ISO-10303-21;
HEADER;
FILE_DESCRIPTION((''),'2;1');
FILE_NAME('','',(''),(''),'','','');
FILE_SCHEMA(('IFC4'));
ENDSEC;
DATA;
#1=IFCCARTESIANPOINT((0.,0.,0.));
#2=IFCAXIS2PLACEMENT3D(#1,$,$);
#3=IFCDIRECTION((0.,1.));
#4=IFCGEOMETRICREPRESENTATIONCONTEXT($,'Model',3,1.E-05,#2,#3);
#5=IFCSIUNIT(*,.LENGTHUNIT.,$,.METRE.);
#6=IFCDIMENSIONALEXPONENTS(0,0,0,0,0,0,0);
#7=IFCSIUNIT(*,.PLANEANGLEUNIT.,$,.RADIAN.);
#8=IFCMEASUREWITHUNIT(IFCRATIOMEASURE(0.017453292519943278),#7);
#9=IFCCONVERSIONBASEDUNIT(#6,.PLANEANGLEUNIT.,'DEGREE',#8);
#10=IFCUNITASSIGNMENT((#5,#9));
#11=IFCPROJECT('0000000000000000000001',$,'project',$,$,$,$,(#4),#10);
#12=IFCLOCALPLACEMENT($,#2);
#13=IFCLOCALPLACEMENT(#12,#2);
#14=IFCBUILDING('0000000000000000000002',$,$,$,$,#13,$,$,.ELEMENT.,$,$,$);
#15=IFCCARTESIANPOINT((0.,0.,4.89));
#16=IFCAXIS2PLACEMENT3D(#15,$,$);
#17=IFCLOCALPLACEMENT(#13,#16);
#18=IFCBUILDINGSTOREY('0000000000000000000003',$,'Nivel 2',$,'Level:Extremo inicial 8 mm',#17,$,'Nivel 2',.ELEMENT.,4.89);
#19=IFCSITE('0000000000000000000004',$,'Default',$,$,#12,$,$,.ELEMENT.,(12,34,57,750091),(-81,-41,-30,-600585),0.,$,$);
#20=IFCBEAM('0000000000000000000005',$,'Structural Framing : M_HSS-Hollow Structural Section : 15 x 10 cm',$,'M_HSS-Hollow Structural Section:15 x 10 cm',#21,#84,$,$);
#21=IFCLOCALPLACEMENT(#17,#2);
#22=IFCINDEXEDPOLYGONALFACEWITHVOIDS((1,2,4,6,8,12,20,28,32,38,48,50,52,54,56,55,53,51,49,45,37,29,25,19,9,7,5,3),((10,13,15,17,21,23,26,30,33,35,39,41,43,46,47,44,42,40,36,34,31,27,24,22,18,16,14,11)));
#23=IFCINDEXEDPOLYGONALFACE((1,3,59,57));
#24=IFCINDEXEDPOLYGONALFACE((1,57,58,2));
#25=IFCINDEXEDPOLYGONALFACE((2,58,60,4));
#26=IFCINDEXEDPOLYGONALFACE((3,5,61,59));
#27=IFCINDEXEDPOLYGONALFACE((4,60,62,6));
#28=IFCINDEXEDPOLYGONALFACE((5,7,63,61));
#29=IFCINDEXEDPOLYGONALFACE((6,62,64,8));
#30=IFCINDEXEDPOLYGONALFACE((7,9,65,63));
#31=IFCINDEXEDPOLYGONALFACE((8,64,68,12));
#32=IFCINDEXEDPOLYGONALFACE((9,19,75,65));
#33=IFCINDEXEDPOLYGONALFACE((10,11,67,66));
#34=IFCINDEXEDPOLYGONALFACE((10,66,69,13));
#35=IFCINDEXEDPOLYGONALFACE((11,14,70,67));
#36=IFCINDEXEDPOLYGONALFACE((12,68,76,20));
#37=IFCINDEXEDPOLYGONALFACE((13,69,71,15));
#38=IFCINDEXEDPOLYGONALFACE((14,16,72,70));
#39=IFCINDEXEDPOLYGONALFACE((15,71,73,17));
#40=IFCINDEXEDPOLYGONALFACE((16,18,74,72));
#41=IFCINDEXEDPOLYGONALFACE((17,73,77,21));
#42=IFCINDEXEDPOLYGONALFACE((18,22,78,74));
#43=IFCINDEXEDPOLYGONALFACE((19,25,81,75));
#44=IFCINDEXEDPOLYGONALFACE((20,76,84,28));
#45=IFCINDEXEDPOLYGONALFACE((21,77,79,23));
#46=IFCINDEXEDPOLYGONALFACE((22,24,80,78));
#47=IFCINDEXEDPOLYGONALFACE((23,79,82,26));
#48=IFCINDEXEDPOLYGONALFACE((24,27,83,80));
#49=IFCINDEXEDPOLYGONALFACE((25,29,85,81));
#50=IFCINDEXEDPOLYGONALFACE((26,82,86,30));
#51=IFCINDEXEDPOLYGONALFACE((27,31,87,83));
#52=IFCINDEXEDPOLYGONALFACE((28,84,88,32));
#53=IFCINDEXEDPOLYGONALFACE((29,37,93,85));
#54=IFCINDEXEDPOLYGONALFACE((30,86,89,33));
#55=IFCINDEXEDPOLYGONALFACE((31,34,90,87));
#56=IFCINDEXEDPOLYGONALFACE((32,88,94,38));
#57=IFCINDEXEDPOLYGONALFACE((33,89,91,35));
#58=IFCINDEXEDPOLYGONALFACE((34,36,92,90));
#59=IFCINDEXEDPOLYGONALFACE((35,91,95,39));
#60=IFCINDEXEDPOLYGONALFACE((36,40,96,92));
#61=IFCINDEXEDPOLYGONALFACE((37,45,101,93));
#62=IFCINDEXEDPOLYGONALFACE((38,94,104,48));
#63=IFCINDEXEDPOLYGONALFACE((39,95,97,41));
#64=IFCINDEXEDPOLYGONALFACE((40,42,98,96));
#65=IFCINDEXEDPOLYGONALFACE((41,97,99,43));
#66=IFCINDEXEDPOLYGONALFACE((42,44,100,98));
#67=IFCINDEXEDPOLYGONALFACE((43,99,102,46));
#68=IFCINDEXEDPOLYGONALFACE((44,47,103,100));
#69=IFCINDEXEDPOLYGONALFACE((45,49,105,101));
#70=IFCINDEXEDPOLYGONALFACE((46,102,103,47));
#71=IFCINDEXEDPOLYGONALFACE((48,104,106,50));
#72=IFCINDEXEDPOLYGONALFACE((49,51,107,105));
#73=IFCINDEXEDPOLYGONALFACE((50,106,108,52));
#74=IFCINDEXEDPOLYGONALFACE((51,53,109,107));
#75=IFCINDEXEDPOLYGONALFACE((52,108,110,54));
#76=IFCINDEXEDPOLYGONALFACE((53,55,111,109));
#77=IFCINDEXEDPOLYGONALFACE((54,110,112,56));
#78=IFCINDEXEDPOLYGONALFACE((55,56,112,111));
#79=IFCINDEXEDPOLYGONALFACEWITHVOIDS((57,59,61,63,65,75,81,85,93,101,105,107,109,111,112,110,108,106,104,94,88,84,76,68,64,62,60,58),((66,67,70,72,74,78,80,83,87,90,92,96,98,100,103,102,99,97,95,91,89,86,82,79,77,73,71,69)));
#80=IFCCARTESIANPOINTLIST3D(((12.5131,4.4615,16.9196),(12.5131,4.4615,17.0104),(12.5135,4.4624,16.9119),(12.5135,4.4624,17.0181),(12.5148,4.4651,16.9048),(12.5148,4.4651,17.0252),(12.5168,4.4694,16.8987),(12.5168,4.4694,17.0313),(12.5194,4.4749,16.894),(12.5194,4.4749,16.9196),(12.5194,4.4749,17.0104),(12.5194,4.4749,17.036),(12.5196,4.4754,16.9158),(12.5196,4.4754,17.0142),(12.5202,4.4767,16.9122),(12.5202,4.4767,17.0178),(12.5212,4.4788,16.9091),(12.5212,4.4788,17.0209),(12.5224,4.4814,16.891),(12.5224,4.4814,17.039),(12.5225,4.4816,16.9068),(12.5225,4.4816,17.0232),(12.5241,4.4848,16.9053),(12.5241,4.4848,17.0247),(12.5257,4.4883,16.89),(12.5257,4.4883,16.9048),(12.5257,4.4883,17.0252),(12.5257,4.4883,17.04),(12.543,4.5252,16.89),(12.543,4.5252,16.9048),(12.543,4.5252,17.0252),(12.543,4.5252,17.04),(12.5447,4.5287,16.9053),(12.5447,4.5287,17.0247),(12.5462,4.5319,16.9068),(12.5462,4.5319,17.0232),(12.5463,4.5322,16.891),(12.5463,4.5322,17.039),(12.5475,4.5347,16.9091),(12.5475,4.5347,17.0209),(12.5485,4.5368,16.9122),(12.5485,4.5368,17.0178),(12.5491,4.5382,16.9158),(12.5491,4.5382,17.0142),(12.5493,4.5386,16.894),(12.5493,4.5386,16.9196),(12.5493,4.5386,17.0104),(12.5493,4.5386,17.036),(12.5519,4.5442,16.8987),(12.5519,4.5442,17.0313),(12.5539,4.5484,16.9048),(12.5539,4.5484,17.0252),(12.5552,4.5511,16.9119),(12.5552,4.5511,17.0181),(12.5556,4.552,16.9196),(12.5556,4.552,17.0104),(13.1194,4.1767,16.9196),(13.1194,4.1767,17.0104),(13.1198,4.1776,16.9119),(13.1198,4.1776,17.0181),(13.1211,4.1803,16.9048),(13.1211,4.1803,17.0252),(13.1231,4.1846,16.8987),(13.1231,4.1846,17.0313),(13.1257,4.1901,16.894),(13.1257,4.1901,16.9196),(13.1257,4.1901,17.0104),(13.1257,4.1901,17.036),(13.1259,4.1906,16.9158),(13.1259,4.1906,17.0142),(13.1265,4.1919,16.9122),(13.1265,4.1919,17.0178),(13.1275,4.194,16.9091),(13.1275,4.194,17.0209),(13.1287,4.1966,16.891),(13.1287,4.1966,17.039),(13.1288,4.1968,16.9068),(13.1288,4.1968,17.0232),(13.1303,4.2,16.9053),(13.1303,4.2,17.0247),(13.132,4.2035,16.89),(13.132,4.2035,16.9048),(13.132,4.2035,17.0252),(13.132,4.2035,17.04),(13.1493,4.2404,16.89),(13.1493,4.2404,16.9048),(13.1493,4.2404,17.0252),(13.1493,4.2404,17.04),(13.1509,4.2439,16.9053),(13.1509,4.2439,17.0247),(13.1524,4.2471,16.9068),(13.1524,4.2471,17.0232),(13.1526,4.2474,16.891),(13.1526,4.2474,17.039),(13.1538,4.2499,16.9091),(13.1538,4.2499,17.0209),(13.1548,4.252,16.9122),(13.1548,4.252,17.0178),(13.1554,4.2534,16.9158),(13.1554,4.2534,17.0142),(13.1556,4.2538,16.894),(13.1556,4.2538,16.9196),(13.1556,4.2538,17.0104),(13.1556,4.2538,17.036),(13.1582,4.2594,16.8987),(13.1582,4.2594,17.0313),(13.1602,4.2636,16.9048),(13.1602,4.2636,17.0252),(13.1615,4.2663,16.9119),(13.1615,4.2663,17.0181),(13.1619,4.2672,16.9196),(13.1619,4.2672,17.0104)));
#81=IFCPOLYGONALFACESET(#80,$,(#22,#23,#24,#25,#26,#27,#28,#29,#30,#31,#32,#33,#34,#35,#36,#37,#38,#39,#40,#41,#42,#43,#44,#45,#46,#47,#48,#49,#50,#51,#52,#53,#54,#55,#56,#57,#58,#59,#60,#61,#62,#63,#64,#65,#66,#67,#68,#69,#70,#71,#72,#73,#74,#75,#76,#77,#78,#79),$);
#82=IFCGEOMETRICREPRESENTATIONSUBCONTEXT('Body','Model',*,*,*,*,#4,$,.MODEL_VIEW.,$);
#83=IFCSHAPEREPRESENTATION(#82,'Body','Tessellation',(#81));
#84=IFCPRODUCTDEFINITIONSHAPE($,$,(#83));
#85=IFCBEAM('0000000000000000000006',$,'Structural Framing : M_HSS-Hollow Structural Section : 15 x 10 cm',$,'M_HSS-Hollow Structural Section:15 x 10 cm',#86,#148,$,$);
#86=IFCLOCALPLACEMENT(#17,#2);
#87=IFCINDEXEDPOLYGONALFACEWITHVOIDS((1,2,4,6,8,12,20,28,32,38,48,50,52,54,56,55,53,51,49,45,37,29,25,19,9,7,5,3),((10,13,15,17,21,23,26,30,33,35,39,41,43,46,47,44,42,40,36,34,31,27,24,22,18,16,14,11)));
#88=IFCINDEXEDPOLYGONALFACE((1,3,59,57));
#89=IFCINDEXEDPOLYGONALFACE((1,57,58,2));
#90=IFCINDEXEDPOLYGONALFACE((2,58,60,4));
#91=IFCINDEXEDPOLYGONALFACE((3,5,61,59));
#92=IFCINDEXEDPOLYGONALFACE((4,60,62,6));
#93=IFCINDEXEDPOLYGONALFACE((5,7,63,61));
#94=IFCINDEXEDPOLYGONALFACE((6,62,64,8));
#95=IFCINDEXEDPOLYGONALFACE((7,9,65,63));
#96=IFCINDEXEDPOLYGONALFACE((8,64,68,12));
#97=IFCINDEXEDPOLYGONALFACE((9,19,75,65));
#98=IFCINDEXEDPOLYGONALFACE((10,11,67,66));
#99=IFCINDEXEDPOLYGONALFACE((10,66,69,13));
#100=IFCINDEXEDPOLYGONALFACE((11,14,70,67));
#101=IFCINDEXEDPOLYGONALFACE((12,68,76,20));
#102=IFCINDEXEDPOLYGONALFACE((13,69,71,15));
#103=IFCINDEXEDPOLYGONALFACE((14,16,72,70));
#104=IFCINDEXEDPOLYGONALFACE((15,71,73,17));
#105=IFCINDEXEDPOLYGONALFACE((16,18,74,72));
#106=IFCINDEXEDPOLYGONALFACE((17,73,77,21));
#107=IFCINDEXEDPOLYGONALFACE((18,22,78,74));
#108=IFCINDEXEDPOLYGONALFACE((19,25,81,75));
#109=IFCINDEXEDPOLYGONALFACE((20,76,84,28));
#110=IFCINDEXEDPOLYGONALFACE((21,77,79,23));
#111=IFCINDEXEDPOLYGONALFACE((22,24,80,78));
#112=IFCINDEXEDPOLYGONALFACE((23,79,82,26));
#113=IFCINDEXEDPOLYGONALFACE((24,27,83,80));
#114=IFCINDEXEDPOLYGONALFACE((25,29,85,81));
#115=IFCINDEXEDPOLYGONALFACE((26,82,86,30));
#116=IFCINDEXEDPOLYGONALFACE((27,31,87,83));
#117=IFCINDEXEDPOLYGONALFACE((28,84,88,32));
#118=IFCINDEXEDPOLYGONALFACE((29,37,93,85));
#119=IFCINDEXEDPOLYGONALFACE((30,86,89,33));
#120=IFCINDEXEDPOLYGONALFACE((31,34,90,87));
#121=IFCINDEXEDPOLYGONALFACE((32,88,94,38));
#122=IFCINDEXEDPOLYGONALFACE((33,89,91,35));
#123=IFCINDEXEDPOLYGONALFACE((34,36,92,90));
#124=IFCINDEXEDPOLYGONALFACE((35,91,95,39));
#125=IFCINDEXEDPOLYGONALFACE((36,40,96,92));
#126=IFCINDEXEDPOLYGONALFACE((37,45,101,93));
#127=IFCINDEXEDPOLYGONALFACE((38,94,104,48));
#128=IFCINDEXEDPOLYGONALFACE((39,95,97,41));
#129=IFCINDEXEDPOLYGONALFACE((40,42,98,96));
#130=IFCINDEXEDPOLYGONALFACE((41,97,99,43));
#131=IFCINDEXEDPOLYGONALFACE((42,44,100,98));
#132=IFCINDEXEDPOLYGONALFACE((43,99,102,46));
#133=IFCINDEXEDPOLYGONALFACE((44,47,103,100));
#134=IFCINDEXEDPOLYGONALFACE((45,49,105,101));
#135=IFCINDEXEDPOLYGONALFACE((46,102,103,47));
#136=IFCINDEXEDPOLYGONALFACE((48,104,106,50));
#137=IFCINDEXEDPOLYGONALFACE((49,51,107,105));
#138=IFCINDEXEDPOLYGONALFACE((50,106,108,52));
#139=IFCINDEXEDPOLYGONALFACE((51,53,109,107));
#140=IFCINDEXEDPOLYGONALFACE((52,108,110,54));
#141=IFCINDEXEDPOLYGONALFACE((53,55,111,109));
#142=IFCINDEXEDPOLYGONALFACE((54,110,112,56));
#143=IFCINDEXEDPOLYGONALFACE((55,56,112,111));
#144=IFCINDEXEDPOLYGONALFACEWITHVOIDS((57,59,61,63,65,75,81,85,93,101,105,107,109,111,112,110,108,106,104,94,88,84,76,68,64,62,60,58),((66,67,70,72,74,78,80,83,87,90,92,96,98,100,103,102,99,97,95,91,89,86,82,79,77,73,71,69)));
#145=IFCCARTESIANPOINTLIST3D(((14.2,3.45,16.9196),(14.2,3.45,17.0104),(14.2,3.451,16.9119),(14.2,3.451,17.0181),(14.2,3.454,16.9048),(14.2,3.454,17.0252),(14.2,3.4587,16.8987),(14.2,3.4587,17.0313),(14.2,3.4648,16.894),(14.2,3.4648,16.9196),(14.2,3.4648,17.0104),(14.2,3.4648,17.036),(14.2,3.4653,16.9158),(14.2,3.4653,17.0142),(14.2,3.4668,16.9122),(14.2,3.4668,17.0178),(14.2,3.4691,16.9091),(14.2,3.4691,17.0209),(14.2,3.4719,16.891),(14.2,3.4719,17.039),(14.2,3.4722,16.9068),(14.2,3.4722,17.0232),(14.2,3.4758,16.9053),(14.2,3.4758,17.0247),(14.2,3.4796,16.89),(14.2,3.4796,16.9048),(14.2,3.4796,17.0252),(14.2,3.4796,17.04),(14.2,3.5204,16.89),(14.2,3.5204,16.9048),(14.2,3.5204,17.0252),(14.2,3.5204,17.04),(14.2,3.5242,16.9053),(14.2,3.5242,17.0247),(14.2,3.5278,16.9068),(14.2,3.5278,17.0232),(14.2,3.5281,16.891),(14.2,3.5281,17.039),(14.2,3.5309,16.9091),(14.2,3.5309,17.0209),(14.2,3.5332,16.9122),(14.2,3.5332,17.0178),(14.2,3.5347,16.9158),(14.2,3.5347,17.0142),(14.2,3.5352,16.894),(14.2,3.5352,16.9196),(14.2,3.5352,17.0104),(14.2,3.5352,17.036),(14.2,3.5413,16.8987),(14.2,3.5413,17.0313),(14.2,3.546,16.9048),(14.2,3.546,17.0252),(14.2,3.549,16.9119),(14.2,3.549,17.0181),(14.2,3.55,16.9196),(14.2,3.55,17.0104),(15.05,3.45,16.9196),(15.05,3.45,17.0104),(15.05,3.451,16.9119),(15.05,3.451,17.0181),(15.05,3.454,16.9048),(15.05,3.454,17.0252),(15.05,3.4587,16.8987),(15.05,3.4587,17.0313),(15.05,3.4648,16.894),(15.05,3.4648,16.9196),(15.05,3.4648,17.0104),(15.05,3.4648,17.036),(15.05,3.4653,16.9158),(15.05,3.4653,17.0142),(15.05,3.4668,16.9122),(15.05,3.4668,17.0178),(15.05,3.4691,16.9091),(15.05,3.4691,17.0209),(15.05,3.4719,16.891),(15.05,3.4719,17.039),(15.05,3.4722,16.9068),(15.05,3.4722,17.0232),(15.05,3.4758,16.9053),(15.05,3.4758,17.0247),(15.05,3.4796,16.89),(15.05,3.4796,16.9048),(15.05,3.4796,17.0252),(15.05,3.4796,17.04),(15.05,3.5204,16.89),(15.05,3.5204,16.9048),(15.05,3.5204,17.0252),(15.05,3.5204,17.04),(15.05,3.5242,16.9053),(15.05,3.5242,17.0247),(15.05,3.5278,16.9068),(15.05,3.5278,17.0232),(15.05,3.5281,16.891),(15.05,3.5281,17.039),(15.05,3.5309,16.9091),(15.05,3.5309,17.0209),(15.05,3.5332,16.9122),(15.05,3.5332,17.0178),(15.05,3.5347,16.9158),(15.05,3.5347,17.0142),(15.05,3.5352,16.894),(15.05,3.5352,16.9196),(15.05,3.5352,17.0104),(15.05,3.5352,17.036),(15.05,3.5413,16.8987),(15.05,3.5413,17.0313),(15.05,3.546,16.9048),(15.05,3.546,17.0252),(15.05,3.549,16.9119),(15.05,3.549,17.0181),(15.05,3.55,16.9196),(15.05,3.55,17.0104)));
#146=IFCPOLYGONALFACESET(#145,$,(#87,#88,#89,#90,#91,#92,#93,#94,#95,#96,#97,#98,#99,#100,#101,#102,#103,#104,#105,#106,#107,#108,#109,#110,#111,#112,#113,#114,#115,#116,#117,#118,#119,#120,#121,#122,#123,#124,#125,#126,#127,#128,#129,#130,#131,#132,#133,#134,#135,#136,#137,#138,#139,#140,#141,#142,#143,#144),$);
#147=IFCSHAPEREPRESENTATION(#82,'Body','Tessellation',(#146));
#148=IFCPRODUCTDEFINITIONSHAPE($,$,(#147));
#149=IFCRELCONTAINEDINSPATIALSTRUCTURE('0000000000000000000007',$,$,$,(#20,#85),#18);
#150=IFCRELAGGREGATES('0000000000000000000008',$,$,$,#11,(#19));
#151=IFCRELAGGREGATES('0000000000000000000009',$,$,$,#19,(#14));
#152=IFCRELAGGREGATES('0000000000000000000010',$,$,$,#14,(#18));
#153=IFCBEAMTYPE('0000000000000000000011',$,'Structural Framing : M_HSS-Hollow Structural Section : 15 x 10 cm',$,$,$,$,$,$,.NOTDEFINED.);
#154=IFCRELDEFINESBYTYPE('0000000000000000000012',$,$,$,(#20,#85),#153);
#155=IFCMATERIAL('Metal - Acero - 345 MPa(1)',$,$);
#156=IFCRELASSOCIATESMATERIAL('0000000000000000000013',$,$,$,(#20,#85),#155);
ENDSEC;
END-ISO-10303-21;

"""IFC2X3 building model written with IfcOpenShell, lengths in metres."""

from ifc_helpers import new_model, entity, si_unit, converted_unit, direction, frame, frame_2d, origin, place, context, subcontext, project, spatial, polyline, circle_curve, parameter, trimmed, segment, composite_curve, outline, extrude, material, type_object, element, save


model = new_model("IFC2X3")

# Units and contexts
model_context = context("Model", 3, precision=1e-05, world=origin(), true_north=direction((0.0, 1.0)))
body_context = subcontext(model_context, "Body", "Model", "MODEL_VIEW")
ifc_project = project(units=[si_unit("LENGTHUNIT", "METRE"), converted_unit("PLANEANGLEUNIT", "DEGREE", entity("IfcRatioMeasure", 0.017453292519943278), si_unit("PLANEANGLEUNIT", "RADIAN"), dimensions=[0, 0, 0, 0, 0, 0, 0])], contexts=[model_context])

# Site, building, storey
site_placement = place(None, origin())
site = spatial("IfcSite", under=ifc_project, at=site_placement, Name="Default", CompositionType="ELEMENT", RefLatitude=(12, 34, 57, 750091), RefLongitude=(-81, -41, -30, -600585), RefElevation=0.0)
building_placement = place(site_placement, origin())
building = spatial("IfcBuilding", under=site, at=building_placement, CompositionType="ELEMENT")
storey_placement = place(building_placement, frame((0.0, 0.0, 4.89)))
storey = spatial("IfcBuildingStorey", under=building, at=storey_placement, Name="Nivel 2", ObjectType="Level:Extremo inicial 8 mm", LongName="Nivel 2", CompositionType="ELEMENT", Elevation=4.89)

# Beams
ifc_material_1 = material(Name="Metal - Acero - 345 MPa(1)")
beam_type_1 = type_object("IfcBeamType", Name="Structural Framing : M_HSS-Hollow Structural Section : 15 x 10 cm", PredefinedType="NOTDEFINED")
beam_1_placement = place(storey_placement, frame((12.5344, 4.5068, 17.04), z_axis=(0.0, 0.0, 1.0), x_axis=(0.905108, -0.425182, 0.0)))
element("IfcBeam", 1, at=beam_1_placement, inside=storey, type_object=beam_type_1, material=ifc_material_1, Name="Structural Framing : M_HSS-Hollow Structural Section : 15 x 10 cm", ObjectType="M_HSS-Hollow Structural Section:15 x 10 cm", context=body_context, shape_type="SweptSolid", body=[
    extrude(outline(composite_curve([segment(trimmed(circle_curve(frame_2d((-0.0204, -0.0454), x_axis=(1.0, 0.0)), 0.0296), [parameter(180.0)], [parameter(270.0)], True, "PARAMETER"), True, "CONTINUOUS"), segment(polyline([(-0.0204, -0.075), (0.0204, -0.075)]), True, "CONTINUOUS"), segment(trimmed(circle_curve(frame_2d((0.0204, -0.0454), x_axis=(1.0, 0.0)), 0.0296), [parameter(270.0)], [parameter(0.0)], True, "PARAMETER"), True, "CONTINUOUS"), segment(polyline([(0.05, -0.0454), (0.05, 0.0454)]), True, "CONTINUOUS"), segment(trimmed(circle_curve(frame_2d((0.0204, 0.0454), x_axis=(1.0, 0.0)), 0.0296), [parameter(360.0)], [parameter(90.0)], True, "PARAMETER"), True, "CONTINUOUS"), segment(polyline([(0.0204, 0.075), (-0.0204, 0.075)]), True, "CONTINUOUS"), segment(trimmed(circle_curve(frame_2d((-0.0204, 0.0454), x_axis=(1.0, 0.0)), 0.0296), [parameter(90.0)], [parameter(180.0)], True, "PARAMETER"), True, "CONTINUOUS"), segment(polyline([(-0.05, 0.0454), (-0.05, -0.0454)]), True, "CONTINUOUS")], self_intersect=False), holes=[composite_curve([segment(polyline([(0.0204, -0.0602), (-0.0204, -0.0602)]), True, "CONTINUOUS"), segment(trimmed(circle_curve(frame_2d((-0.0204, -0.0454), x_axis=(1.0, 0.0)), 0.0148), [parameter(180.0)], [parameter(270.0)], True, "PARAMETER"), False, "CONTINUOUS"), segment(polyline([(-0.0352, -0.0454), (-0.0352, 0.0454)]), True, "CONTINUOUS"), segment(trimmed(circle_curve(frame_2d((-0.0204, 0.0454), x_axis=(1.0, 0.0)), 0.0148), [parameter(90.0)], [parameter(180.0)], True, "PARAMETER"), False, "CONTINUOUS"), segment(polyline([(-0.0204, 0.0602), (0.0204, 0.0602)]), True, "CONTINUOUS"), segment(trimmed(circle_curve(frame_2d((0.0204, 0.0454), x_axis=(1.0, 0.0)), 0.0148), [parameter(0.0)], [parameter(90.0)], True, "PARAMETER"), False, "CONTINUOUS"), segment(polyline([(0.0352, 0.0454), (0.0352, -0.0454)]), True, "CONTINUOUS"), segment(trimmed(circle_curve(frame_2d((0.0204, -0.0454), x_axis=(1.0, 0.0)), 0.0148), [parameter(270.0)], [parameter(0.0)], True, "PARAMETER"), False, "CONTINUOUS")], self_intersect=False)]), frame((0.0, 0.0, -0.075), z_axis=(1.0, 0.0, 0.0), x_axis=(0.0, -1.0, 0.0)), (0.0, 0.0, 1.0), 0.6698),
])
beam_2_placement = place(storey_placement, frame((13.85, 3.5, 17.04)))
element("IfcBeam", 2, at=beam_2_placement, inside=storey, type_object=beam_type_1, material=ifc_material_1, Name="Structural Framing : M_HSS-Hollow Structural Section : 15 x 10 cm", ObjectType="M_HSS-Hollow Structural Section:15 x 10 cm", context=body_context, shape_type="SweptSolid", body=[
    extrude(outline(composite_curve([segment(trimmed(circle_curve(frame_2d((-0.0204, -0.0454), x_axis=(1.0, 0.0)), 0.0296), [parameter(180.0)], [parameter(270.0)], True, "PARAMETER"), True, "CONTINUOUS"), segment(polyline([(-0.0204, -0.075), (0.0204, -0.075)]), True, "CONTINUOUS"), segment(trimmed(circle_curve(frame_2d((0.0204, -0.0454), x_axis=(1.0, 0.0)), 0.0296), [parameter(270.0)], [parameter(0.0)], True, "PARAMETER"), True, "CONTINUOUS"), segment(polyline([(0.05, -0.0454), (0.05, 0.0454)]), True, "CONTINUOUS"), segment(trimmed(circle_curve(frame_2d((0.0204, 0.0454), x_axis=(1.0, 0.0)), 0.0296), [parameter(360.0)], [parameter(90.0)], True, "PARAMETER"), True, "CONTINUOUS"), segment(polyline([(0.0204, 0.075), (-0.0204, 0.075)]), True, "CONTINUOUS"), segment(trimmed(circle_curve(frame_2d((-0.0204, 0.0454), x_axis=(1.0, 0.0)), 0.0296), [parameter(90.0)], [parameter(180.0)], True, "PARAMETER"), True, "CONTINUOUS"), segment(polyline([(-0.05, 0.0454), (-0.05, -0.0454)]), True, "CONTINUOUS")], self_intersect=False), holes=[composite_curve([segment(polyline([(0.0204, -0.0602), (-0.0204, -0.0602)]), True, "CONTINUOUS"), segment(trimmed(circle_curve(frame_2d((-0.0204, -0.0454), x_axis=(1.0, 0.0)), 0.0148), [parameter(180.0)], [parameter(270.0)], True, "PARAMETER"), False, "CONTINUOUS"), segment(polyline([(-0.0352, -0.0454), (-0.0352, 0.0454)]), True, "CONTINUOUS"), segment(trimmed(circle_curve(frame_2d((-0.0204, 0.0454), x_axis=(1.0, 0.0)), 0.0148), [parameter(90.0)], [parameter(180.0)], True, "PARAMETER"), False, "CONTINUOUS"), segment(polyline([(-0.0204, 0.0602), (0.0204, 0.0602)]), True, "CONTINUOUS"), segment(trimmed(circle_curve(frame_2d((0.0204, 0.0454), x_axis=(1.0, 0.0)), 0.0148), [parameter(0.0)], [parameter(90.0)], True, "PARAMETER"), False, "CONTINUOUS"), segment(polyline([(0.0352, 0.0454), (0.0352, -0.0454)]), True, "CONTINUOUS"), segment(trimmed(circle_curve(frame_2d((0.0204, -0.0454), x_axis=(1.0, 0.0)), 0.0148), [parameter(270.0)], [parameter(0.0)], True, "PARAMETER"), False, "CONTINUOUS")], self_intersect=False)]), frame((0.35, 0.0, -0.075), z_axis=(1.0, 0.0, 0.0), x_axis=(0.0, -1.0, 0.0)), (0.0, 0.0, 1.0), 0.85),
])

save(model, "model.ifc")
